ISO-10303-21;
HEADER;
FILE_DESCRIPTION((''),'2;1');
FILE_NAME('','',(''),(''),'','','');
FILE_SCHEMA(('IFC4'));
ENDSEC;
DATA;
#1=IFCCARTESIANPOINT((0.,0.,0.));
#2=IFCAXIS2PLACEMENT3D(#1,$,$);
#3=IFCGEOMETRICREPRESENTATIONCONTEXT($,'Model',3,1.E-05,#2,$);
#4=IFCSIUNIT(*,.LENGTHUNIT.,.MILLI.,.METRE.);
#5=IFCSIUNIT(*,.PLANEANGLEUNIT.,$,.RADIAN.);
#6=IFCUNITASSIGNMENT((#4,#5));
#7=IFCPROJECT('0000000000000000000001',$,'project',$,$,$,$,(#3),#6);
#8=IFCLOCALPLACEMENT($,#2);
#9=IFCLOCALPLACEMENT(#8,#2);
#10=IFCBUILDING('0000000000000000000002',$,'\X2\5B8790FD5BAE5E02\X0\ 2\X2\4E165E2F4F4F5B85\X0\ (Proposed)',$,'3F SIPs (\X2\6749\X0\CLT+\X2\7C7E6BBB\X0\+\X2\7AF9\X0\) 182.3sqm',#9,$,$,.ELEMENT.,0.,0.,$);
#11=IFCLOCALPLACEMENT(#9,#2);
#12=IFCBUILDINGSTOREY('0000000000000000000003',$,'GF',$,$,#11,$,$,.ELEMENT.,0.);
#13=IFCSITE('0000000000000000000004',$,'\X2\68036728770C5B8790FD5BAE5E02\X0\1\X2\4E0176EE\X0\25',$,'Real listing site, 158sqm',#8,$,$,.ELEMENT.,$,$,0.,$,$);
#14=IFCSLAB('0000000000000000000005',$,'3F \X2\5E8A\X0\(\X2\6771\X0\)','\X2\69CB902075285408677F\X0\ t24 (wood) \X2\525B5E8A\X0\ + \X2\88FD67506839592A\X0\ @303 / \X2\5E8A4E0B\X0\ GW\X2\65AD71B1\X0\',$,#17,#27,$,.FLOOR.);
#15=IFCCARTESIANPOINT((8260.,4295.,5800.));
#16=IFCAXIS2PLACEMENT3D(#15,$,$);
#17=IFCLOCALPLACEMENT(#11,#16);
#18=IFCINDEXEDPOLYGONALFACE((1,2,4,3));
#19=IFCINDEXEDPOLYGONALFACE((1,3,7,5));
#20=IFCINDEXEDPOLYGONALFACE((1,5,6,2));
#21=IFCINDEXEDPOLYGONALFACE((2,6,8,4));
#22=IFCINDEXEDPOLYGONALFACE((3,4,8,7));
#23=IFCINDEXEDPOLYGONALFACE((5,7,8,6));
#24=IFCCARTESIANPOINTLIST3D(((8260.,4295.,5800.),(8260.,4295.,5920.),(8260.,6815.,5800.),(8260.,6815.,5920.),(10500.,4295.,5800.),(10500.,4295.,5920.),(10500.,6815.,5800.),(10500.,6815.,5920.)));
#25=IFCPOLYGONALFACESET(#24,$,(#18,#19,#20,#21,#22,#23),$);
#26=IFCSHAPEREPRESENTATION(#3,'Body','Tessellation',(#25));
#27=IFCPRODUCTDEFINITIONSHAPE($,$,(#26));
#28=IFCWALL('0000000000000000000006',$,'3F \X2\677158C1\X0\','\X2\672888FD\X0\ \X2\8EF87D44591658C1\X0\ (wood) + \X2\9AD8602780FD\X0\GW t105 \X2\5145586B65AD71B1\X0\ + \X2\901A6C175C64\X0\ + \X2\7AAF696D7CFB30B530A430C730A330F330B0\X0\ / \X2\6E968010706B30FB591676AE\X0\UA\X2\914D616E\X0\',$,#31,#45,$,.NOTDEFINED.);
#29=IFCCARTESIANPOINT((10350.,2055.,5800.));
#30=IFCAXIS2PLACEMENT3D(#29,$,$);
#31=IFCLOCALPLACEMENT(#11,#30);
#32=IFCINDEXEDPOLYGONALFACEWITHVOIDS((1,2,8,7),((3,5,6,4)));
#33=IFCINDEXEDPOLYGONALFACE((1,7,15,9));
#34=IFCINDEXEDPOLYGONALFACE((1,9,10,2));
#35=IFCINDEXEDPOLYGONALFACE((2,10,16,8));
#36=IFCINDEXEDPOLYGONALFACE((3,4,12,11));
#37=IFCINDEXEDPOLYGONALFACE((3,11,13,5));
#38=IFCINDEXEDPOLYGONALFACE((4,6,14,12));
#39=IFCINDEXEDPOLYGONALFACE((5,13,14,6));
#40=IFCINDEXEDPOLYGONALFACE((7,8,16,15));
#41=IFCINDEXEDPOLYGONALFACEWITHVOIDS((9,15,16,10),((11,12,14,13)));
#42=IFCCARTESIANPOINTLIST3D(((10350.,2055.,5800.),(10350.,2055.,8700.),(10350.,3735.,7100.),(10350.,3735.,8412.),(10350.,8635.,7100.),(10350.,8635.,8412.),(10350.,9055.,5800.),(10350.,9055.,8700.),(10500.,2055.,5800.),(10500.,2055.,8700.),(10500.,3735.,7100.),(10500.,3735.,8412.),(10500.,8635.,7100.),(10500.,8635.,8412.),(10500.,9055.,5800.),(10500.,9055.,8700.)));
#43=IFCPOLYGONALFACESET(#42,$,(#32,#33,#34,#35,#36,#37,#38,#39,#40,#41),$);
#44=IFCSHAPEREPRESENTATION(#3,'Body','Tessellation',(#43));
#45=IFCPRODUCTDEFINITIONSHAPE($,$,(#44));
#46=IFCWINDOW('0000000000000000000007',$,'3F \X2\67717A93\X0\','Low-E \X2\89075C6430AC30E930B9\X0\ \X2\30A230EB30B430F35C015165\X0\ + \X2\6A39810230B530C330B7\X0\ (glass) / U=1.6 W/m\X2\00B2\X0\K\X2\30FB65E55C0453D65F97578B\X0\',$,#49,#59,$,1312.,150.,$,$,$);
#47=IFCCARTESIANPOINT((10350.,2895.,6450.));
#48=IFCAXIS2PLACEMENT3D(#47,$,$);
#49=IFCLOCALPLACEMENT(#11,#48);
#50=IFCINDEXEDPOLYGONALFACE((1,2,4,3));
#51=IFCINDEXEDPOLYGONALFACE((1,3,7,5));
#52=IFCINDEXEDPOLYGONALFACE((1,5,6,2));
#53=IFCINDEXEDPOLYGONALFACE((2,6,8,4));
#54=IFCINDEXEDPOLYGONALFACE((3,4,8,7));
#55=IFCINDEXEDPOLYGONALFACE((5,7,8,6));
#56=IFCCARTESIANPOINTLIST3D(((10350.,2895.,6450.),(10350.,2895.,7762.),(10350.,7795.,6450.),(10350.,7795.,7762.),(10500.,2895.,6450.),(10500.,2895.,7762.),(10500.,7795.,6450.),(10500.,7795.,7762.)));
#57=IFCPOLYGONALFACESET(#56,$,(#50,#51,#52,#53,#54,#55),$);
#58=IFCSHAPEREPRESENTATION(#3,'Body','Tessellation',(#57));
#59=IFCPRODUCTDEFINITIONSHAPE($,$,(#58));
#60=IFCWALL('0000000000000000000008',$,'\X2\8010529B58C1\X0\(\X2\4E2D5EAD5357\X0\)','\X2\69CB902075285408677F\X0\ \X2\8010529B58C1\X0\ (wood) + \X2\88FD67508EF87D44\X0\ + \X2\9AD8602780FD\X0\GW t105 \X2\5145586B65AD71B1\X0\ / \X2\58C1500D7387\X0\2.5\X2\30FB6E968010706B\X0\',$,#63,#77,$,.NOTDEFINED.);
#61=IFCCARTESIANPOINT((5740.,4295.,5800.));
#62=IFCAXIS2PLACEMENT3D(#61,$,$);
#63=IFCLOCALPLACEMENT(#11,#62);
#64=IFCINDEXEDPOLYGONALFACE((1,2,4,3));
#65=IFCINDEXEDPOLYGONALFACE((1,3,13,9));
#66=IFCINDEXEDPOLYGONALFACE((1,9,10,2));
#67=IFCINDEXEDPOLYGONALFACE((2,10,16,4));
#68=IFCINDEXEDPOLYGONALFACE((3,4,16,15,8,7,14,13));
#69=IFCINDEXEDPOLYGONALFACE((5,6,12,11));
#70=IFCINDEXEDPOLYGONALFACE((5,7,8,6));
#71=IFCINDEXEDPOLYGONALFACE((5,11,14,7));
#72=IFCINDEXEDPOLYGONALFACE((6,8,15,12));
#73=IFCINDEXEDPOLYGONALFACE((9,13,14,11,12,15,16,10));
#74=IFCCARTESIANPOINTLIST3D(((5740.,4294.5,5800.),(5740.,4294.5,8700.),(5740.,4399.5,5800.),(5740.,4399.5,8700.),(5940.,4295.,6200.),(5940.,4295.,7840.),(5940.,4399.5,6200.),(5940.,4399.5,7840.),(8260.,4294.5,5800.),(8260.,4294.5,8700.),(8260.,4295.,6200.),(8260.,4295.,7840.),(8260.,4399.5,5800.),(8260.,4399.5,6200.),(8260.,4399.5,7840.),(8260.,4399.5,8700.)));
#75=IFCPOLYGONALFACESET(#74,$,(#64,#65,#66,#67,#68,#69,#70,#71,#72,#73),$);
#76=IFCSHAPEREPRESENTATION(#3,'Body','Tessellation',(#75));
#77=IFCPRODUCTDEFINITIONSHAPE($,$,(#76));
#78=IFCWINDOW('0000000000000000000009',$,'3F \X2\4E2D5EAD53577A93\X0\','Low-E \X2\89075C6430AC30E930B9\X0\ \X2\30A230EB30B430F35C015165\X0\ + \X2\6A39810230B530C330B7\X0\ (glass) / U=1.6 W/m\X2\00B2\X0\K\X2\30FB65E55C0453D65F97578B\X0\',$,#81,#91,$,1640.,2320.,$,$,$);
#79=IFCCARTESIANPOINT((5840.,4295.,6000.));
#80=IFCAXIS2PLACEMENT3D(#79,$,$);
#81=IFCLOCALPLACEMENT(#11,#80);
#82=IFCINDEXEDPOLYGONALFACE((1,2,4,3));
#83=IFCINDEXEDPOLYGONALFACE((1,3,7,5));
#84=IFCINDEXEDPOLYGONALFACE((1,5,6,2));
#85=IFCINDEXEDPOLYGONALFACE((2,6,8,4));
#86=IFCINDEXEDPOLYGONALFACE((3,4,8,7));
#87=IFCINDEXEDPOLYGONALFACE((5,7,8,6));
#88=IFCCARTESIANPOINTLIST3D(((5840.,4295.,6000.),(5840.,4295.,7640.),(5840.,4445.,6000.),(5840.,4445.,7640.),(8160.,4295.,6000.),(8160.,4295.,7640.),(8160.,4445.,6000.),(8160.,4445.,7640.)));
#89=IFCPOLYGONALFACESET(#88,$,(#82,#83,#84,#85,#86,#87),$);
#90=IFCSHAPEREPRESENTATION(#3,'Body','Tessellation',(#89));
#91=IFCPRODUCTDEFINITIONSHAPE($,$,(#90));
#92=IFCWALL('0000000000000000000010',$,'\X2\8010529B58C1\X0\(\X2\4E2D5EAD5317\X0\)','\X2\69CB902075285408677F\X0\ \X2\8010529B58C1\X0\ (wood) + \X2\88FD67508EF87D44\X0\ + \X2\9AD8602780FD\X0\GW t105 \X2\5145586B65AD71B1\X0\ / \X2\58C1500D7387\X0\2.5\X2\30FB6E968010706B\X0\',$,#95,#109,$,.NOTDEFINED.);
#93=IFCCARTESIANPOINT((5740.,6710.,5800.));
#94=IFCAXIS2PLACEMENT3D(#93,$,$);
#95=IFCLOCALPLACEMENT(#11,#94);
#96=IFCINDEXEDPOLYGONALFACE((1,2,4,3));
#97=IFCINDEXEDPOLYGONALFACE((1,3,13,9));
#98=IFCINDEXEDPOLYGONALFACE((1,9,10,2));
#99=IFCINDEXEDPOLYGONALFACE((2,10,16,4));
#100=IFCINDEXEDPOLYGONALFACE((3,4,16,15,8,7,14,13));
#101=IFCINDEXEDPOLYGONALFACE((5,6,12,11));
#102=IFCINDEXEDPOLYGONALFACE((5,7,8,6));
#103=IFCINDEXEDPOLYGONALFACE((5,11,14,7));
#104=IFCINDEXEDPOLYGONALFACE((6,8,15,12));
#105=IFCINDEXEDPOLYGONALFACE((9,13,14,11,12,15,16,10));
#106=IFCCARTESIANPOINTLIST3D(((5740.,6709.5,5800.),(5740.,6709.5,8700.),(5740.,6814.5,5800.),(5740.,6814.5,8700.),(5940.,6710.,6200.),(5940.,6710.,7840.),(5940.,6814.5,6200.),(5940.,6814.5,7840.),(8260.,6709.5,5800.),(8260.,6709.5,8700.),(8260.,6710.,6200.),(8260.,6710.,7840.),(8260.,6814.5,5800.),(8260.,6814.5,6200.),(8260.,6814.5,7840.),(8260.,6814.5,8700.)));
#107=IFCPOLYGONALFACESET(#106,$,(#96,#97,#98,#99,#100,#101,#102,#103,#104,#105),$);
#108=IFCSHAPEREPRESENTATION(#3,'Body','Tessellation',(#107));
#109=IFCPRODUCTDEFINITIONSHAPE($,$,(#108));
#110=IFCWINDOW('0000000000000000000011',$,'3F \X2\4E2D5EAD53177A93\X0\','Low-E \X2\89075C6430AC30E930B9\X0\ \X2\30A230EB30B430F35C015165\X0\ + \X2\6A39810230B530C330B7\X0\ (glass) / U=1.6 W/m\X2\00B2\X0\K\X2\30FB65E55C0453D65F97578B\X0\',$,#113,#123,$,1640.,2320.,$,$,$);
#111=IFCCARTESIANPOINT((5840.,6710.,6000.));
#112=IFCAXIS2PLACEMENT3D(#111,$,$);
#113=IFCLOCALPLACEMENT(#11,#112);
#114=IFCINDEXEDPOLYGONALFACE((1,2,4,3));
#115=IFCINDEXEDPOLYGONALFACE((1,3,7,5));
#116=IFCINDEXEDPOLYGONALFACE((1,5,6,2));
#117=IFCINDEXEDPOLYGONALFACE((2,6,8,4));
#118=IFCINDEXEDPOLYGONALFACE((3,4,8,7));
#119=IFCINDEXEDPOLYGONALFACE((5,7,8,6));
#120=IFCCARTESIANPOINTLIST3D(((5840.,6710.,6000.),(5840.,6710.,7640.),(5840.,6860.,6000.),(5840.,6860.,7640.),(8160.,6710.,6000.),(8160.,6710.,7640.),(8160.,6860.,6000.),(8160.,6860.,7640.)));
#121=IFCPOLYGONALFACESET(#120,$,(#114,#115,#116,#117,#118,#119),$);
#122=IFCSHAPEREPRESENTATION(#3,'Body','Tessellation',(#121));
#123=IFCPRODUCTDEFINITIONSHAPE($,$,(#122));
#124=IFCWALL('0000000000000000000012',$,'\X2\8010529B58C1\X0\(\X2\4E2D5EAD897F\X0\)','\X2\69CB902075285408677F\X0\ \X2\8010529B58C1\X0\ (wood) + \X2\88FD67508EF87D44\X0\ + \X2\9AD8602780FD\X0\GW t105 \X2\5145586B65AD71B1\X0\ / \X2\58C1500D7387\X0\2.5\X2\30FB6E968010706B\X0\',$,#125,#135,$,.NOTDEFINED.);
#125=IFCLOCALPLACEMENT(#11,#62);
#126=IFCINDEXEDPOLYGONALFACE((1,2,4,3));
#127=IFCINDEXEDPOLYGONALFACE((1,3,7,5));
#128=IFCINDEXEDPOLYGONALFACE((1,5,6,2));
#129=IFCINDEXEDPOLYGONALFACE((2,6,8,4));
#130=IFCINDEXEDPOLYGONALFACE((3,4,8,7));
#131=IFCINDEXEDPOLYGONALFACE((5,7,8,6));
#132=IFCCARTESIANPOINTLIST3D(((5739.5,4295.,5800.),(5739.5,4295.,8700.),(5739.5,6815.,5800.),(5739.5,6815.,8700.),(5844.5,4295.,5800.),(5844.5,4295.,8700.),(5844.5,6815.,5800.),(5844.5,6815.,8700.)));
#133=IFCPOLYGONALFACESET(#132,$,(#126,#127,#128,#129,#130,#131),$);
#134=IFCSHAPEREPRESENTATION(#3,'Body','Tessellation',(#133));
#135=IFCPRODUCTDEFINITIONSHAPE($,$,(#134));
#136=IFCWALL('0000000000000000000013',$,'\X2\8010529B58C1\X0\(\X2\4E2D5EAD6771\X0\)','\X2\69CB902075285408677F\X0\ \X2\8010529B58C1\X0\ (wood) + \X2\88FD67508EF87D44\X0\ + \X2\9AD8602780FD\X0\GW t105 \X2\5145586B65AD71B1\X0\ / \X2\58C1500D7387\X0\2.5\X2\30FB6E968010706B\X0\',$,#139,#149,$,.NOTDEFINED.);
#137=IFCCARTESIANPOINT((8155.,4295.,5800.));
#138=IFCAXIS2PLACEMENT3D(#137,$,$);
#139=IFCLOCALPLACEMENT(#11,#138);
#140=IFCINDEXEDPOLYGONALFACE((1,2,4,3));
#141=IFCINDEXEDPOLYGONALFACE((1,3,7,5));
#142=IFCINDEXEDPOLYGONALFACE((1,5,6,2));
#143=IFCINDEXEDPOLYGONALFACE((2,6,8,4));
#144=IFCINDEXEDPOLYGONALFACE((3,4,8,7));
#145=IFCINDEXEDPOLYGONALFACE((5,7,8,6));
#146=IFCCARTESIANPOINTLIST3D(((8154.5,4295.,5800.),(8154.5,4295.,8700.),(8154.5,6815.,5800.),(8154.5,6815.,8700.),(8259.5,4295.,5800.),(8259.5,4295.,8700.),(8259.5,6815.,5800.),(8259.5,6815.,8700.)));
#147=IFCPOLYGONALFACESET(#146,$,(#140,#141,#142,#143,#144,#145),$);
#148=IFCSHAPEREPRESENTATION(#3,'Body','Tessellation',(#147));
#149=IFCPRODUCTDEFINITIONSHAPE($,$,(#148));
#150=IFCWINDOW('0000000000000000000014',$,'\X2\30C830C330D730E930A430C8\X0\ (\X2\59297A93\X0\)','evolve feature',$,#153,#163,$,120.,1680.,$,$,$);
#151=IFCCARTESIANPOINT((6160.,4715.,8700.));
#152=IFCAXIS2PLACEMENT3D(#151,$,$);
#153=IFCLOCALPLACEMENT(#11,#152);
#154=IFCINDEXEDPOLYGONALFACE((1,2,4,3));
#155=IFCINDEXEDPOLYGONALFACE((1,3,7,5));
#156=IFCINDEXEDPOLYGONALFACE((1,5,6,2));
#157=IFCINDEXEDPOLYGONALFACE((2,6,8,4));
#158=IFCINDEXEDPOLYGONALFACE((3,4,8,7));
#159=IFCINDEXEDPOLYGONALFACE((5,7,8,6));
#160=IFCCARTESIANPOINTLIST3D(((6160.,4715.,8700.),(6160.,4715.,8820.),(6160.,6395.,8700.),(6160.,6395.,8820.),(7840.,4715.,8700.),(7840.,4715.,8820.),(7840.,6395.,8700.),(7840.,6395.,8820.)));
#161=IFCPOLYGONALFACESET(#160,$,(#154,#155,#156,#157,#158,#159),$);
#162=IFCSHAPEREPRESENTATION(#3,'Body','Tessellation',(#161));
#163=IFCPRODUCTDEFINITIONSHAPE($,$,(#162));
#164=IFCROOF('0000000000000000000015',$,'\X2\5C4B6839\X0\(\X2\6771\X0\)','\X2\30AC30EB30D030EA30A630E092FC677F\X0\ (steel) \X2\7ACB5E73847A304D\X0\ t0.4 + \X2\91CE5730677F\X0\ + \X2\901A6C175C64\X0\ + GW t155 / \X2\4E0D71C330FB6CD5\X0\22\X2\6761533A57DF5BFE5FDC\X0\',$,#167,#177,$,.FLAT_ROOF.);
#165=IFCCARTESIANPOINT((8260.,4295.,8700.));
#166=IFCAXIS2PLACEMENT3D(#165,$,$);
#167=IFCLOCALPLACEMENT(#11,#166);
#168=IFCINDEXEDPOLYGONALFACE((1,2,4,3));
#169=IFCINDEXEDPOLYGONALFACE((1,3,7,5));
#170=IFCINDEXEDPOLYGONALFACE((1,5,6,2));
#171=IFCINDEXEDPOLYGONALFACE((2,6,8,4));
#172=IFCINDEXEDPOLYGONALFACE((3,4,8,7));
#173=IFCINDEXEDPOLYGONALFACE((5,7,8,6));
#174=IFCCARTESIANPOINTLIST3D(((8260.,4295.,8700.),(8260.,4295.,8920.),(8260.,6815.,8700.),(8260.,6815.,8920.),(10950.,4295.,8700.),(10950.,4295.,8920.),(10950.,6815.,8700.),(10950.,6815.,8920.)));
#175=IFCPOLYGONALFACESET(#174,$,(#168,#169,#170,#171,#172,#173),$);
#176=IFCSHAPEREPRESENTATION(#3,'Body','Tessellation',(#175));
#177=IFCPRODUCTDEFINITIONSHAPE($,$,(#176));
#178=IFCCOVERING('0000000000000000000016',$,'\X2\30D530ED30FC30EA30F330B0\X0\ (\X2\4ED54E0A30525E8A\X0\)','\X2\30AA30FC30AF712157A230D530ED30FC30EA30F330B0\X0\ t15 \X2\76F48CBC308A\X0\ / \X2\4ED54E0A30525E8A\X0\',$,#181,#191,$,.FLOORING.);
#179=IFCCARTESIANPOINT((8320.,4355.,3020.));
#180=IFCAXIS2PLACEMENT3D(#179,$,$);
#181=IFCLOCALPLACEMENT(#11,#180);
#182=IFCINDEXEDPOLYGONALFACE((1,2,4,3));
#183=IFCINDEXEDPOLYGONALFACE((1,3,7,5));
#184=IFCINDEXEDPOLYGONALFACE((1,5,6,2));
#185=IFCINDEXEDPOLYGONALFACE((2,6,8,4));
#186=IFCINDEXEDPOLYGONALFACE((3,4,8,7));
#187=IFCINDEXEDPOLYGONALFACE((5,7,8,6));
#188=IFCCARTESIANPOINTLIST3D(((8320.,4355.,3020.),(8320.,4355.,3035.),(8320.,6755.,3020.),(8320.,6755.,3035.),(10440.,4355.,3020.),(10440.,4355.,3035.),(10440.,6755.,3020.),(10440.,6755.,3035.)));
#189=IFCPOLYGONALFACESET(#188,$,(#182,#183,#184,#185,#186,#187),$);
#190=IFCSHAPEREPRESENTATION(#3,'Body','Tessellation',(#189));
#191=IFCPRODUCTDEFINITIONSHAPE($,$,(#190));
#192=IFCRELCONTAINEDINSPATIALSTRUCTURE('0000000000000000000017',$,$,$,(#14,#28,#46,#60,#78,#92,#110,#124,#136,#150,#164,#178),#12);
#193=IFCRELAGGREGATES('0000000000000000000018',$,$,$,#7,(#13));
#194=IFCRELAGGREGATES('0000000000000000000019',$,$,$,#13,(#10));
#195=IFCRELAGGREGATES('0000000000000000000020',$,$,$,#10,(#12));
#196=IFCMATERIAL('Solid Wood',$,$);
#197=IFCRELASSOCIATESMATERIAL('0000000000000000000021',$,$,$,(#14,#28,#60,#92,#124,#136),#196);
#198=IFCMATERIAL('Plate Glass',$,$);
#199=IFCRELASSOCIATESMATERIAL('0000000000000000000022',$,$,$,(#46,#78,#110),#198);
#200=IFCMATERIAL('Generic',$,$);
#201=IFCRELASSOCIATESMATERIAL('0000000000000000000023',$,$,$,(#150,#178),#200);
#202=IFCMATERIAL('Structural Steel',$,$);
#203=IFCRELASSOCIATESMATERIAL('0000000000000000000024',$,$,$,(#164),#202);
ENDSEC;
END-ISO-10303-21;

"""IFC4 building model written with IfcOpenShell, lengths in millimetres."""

from ifc_helpers import new_model, si_unit, frame, frame_2d, origin, place, context, project, spatial, rectangle, extrude, material, element, fill, save


model = new_model("IFC4")

# Units and contexts
model_context = context("Model", 3, precision=1e-05, world=origin())
ifc_project = project(units=[si_unit("LENGTHUNIT", "METRE", prefix="MILLI"), si_unit("PLANEANGLEUNIT", "RADIAN")], contexts=[model_context])

# Site, building, storey
site_placement = place(None, origin())
site = spatial("IfcSite", under=ifc_project, at=site_placement, Name="栃木県宇都宮市1丁目25", ObjectType="Real listing site, 158sqm", CompositionType="ELEMENT", RefElevation=0.0)
building_placement = place(site_placement, origin())
building = spatial("IfcBuilding", under=site, at=building_placement, Name="宇都宮市 2世帯住宅 (Proposed)", ObjectType="3F SIPs (杉CLT+籾殻+竹) 182.3sqm", CompositionType="ELEMENT", ElevationOfRefHeight=0.0, ElevationOfTerrain=0.0)
storey_placement = place(building_placement, origin())
storey = spatial("IfcBuildingStorey", under=building, at=storey_placement, Name="GF", CompositionType="ELEMENT", Elevation=0.0)

# Slab
ifc_material_1 = material(Name="Solid Wood")
slab_placement = place(storey_placement, frame((8260.0, 4295.0, 5800.0)))
element("IfcSlab", 1, at=slab_placement, inside=storey, material=ifc_material_1, Name="3F 床(東)", Description="構造用合板 t24 (wood) 剛床 + 製材根太 @303 / 床下 GW断熱", PredefinedType="FLOOR", context=model_context, shape_type="SweptSolid", body=[
    extrude(rectangle(XDim=2240.0, YDim=2520.0, at=frame_2d((1120.0, 1260.0))), frame((8260.0, 4295.0, 5800.0)), (0.0, 0.0, 1.0), 120.0),
])

# Walls, openings, windows
wall_1_placement = place(storey_placement, frame((10350.0, 2055.0, 5800.0)))
wall_1 = element("IfcWall", 2, at=wall_1_placement, inside=storey, material=ifc_material_1, Name="3F 東壁", Description="木製 軸組外壁 (wood) + 高性能GW t105 充填断熱 + 通気層 + 窯業系サイディング / 準耐火・外皮UA配慮", PredefinedType="NOTDEFINED", context=model_context, shape_type="SweptSolid", body=[
    extrude(rectangle(XDim=150.0, YDim=7000.0, at=frame_2d((75.0, 3500.0))), frame((10350.0, 2055.0, 5800.0)), (0.0, 0.0, 1.0), 2900.0),
])
opening_1_placement = place(storey_placement, frame((10350.0, 2895.0, 6450.0)))
opening_1 = element("IfcOpeningElement", 3, at=opening_1_placement, cuts=wall_1, PredefinedType="NOTDEFINED", context=model_context, shape_type="SweptSolid", body=[
    extrude(rectangle(XDim=150.0, YDim=4900.0, at=frame_2d((75.0, 2450.0))), frame((10350.0, 2895.0, 6450.0)), (0.0, 0.0, 1.0), 1312.0),
])
ifc_material_2 = material(Name="Plate Glass")
window_1_placement = place(storey_placement, frame((10350.0, 2895.0, 6450.0)))
window_1 = element("IfcWindow", 4, at=window_1_placement, inside=storey, material=ifc_material_2, Name="3F 東窓", Description="Low-E 複層ガラス アルゴン封入 + 樹脂サッシ (glass) / U=1.6 W/m²K・日射取得型", OverallHeight=1312.0, OverallWidth=150.0, context=model_context, shape_type="SweptSolid", body=[
    extrude(rectangle(XDim=150.0, YDim=4900.0, at=frame_2d((75.0, 2450.0))), frame((10350.0, 2895.0, 6450.0)), (0.0, 0.0, 1.0), 1312.0),
])
fill(opening_1, window_1)
wall_2_placement = place(storey_placement, frame((5740.0, 4295.0, 5800.0)))
wall_2 = element("IfcWall", 5, at=wall_2_placement, inside=storey, material=ifc_material_1, Name="耐力壁(中庭南)", Description="構造用合板 耐力壁 (wood) + 製材軸組 + 高性能GW t105 充填断熱 / 壁倍率2.5・準耐火", PredefinedType="NOTDEFINED", context=model_context, shape_type="SweptSolid", body=[
    extrude(rectangle(XDim=2520.0, YDim=105.0, at=frame_2d((1260.0, 52.0))), frame((5740.0, 4295.0, 5800.0)), (0.0, 0.0, 1.0), 2900.0),
])
opening_2_placement = place(storey_placement, frame((5840.0, 4295.0, 6000.0)))
opening_2 = element("IfcOpeningElement", 6, at=opening_2_placement, cuts=wall_2, PredefinedType="NOTDEFINED", context=model_context, shape_type="SweptSolid", body=[
    extrude(rectangle(XDim=2320.0, YDim=150.0, at=frame_2d((1160.0, 75.0))), frame((5840.0, 4295.0, 6000.0)), (0.0, 0.0, 1.0), 1640.0),
])
window_2_placement = place(storey_placement, frame((5840.0, 4295.0, 6000.0)))
window_2 = element("IfcWindow", 7, at=window_2_placement, inside=storey, material=ifc_material_2, Name="3F 中庭南窓", Description="Low-E 複層ガラス アルゴン封入 + 樹脂サッシ (glass) / U=1.6 W/m²K・日射取得型", OverallHeight=1640.0, OverallWidth=2320.0, context=model_context, shape_type="SweptSolid", body=[
    extrude(rectangle(XDim=2320.0, YDim=150.0, at=frame_2d((1160.0, 75.0))), frame((5840.0, 4295.0, 6000.0)), (0.0, 0.0, 1.0), 1640.0),
])
fill(opening_2, window_2)
wall_3_placement = place(storey_placement, frame((5740.0, 6710.0, 5800.0)))
wall_3 = element("IfcWall", 8, at=wall_3_placement, inside=storey, material=ifc_material_1, Name="耐力壁(中庭北)", Description="構造用合板 耐力壁 (wood) + 製材軸組 + 高性能GW t105 充填断熱 / 壁倍率2.5・準耐火", PredefinedType="NOTDEFINED", context=model_context, shape_type="SweptSolid", body=[
    extrude(rectangle(XDim=2520.0, YDim=105.0, at=frame_2d((1260.0, 52.0))), frame((5740.0, 6710.0, 5800.0)), (0.0, 0.0, 1.0), 2900.0),
])
opening_3_placement = place(storey_placement, frame((5840.0, 6710.0, 6000.0)))
opening_3 = element("IfcOpeningElement", 9, at=opening_3_placement, cuts=wall_3, PredefinedType="NOTDEFINED", context=model_context, shape_type="SweptSolid", body=[
    extrude(rectangle(XDim=2320.0, YDim=150.0, at=frame_2d((1160.0, 75.0))), frame((5840.0, 6710.0, 6000.0)), (0.0, 0.0, 1.0), 1640.0),
])
window_3_placement = place(storey_placement, frame((5840.0, 6710.0, 6000.0)))
window_3 = element("IfcWindow", 10, at=window_3_placement, inside=storey, material=ifc_material_2, Name="3F 中庭北窓", Description="Low-E 複層ガラス アルゴン封入 + 樹脂サッシ (glass) / U=1.6 W/m²K・日射取得型", OverallHeight=1640.0, OverallWidth=2320.0, context=model_context, shape_type="SweptSolid", body=[
    extrude(rectangle(XDim=2320.0, YDim=150.0, at=frame_2d((1160.0, 75.0))), frame((5840.0, 6710.0, 6000.0)), (0.0, 0.0, 1.0), 1640.0),
])
fill(opening_3, window_3)

# Walls
wall_4_placement = place(storey_placement, frame((5740.0, 4295.0, 5800.0)))
element("IfcWall", 11, at=wall_4_placement, inside=storey, material=ifc_material_1, Name="耐力壁(中庭西)", Description="構造用合板 耐力壁 (wood) + 製材軸組 + 高性能GW t105 充填断熱 / 壁倍率2.5・準耐火", PredefinedType="NOTDEFINED", context=model_context, shape_type="SweptSolid", body=[
    extrude(rectangle(XDim=105.0, YDim=2520.0, at=frame_2d((52.0, 1260.0))), frame((5740.0, 4295.0, 5800.0)), (0.0, 0.0, 1.0), 2900.0),
])
wall_5_placement = place(storey_placement, frame((8155.0, 4295.0, 5800.0)))
element("IfcWall", 12, at=wall_5_placement, inside=storey, material=ifc_material_1, Name="耐力壁(中庭東)", Description="構造用合板 耐力壁 (wood) + 製材軸組 + 高性能GW t105 充填断熱 / 壁倍率2.5・準耐火", PredefinedType="NOTDEFINED", context=model_context, shape_type="SweptSolid", body=[
    extrude(rectangle(XDim=105.0, YDim=2520.0, at=frame_2d((52.0, 1260.0))), frame((8155.0, 4295.0, 5800.0)), (0.0, 0.0, 1.0), 2900.0),
])

# Window
ifc_material_3 = material(Name="Generic")
window_4_placement = place(storey_placement, frame((6160.0, 4715.0, 8700.0)))
element("IfcWindow", 13, at=window_4_placement, inside=storey, material=ifc_material_3, Name="トップライト (天窓)", Description="evolve feature", OverallHeight=120.0, OverallWidth=1680.0, context=model_context, shape_type="SweptSolid", body=[
    extrude(rectangle(XDim=1680.0, YDim=1680.0, at=frame_2d((840.0, 840.0))), frame((6160.0, 4715.0, 8700.0)), (0.0, 0.0, 1.0), 120.0),
])

# Roof
ifc_material_4 = material(Name="Structural Steel")
for number, where, name in (
    (14, (8260.0, 4295.0, 8700.0), "屋根(東)"),
):
    element("IfcRoof", number, at=place(storey_placement, frame(where)), inside=storey, material=ifc_material_4, Name=name, Description="ガルバリウム鋼板 (steel) 立平葺き t0.4 + 野地板 + 通気層 + GW t155 / 不燃・法22条区域対応", PredefinedType="FLAT_ROOF", context=model_context, shape_type="SweptSolid", body=[
        extrude(rectangle(XDim=2690.0, YDim=2520.0, at=frame_2d((1345.0, 1260.0))), frame((8260.0, 4295.0, 8700.0)), (0.0, 0.0, 1.0), 220.0),
    ])

# Covering
covering_1_placement = place(storey_placement, frame((8320.0, 4355.0, 3020.0)))
element("IfcCovering", 15, at=covering_1_placement, inside=storey, material=ifc_material_3, Name="フローリング (仕上げ床)", Description="オーク無垢フローリング t15 直貼り / 仕上げ床", PredefinedType="FLOORING", context=model_context, shape_type="SweptSolid", body=[
    extrude(rectangle(XDim=2120.0, YDim=2400.0, at=frame_2d((1060.0, 1200.0))), frame((8320.0, 4355.0, 3020.0)), (0.0, 0.0, 1.0), 15.0),
])

save(model, "model.ifc")
